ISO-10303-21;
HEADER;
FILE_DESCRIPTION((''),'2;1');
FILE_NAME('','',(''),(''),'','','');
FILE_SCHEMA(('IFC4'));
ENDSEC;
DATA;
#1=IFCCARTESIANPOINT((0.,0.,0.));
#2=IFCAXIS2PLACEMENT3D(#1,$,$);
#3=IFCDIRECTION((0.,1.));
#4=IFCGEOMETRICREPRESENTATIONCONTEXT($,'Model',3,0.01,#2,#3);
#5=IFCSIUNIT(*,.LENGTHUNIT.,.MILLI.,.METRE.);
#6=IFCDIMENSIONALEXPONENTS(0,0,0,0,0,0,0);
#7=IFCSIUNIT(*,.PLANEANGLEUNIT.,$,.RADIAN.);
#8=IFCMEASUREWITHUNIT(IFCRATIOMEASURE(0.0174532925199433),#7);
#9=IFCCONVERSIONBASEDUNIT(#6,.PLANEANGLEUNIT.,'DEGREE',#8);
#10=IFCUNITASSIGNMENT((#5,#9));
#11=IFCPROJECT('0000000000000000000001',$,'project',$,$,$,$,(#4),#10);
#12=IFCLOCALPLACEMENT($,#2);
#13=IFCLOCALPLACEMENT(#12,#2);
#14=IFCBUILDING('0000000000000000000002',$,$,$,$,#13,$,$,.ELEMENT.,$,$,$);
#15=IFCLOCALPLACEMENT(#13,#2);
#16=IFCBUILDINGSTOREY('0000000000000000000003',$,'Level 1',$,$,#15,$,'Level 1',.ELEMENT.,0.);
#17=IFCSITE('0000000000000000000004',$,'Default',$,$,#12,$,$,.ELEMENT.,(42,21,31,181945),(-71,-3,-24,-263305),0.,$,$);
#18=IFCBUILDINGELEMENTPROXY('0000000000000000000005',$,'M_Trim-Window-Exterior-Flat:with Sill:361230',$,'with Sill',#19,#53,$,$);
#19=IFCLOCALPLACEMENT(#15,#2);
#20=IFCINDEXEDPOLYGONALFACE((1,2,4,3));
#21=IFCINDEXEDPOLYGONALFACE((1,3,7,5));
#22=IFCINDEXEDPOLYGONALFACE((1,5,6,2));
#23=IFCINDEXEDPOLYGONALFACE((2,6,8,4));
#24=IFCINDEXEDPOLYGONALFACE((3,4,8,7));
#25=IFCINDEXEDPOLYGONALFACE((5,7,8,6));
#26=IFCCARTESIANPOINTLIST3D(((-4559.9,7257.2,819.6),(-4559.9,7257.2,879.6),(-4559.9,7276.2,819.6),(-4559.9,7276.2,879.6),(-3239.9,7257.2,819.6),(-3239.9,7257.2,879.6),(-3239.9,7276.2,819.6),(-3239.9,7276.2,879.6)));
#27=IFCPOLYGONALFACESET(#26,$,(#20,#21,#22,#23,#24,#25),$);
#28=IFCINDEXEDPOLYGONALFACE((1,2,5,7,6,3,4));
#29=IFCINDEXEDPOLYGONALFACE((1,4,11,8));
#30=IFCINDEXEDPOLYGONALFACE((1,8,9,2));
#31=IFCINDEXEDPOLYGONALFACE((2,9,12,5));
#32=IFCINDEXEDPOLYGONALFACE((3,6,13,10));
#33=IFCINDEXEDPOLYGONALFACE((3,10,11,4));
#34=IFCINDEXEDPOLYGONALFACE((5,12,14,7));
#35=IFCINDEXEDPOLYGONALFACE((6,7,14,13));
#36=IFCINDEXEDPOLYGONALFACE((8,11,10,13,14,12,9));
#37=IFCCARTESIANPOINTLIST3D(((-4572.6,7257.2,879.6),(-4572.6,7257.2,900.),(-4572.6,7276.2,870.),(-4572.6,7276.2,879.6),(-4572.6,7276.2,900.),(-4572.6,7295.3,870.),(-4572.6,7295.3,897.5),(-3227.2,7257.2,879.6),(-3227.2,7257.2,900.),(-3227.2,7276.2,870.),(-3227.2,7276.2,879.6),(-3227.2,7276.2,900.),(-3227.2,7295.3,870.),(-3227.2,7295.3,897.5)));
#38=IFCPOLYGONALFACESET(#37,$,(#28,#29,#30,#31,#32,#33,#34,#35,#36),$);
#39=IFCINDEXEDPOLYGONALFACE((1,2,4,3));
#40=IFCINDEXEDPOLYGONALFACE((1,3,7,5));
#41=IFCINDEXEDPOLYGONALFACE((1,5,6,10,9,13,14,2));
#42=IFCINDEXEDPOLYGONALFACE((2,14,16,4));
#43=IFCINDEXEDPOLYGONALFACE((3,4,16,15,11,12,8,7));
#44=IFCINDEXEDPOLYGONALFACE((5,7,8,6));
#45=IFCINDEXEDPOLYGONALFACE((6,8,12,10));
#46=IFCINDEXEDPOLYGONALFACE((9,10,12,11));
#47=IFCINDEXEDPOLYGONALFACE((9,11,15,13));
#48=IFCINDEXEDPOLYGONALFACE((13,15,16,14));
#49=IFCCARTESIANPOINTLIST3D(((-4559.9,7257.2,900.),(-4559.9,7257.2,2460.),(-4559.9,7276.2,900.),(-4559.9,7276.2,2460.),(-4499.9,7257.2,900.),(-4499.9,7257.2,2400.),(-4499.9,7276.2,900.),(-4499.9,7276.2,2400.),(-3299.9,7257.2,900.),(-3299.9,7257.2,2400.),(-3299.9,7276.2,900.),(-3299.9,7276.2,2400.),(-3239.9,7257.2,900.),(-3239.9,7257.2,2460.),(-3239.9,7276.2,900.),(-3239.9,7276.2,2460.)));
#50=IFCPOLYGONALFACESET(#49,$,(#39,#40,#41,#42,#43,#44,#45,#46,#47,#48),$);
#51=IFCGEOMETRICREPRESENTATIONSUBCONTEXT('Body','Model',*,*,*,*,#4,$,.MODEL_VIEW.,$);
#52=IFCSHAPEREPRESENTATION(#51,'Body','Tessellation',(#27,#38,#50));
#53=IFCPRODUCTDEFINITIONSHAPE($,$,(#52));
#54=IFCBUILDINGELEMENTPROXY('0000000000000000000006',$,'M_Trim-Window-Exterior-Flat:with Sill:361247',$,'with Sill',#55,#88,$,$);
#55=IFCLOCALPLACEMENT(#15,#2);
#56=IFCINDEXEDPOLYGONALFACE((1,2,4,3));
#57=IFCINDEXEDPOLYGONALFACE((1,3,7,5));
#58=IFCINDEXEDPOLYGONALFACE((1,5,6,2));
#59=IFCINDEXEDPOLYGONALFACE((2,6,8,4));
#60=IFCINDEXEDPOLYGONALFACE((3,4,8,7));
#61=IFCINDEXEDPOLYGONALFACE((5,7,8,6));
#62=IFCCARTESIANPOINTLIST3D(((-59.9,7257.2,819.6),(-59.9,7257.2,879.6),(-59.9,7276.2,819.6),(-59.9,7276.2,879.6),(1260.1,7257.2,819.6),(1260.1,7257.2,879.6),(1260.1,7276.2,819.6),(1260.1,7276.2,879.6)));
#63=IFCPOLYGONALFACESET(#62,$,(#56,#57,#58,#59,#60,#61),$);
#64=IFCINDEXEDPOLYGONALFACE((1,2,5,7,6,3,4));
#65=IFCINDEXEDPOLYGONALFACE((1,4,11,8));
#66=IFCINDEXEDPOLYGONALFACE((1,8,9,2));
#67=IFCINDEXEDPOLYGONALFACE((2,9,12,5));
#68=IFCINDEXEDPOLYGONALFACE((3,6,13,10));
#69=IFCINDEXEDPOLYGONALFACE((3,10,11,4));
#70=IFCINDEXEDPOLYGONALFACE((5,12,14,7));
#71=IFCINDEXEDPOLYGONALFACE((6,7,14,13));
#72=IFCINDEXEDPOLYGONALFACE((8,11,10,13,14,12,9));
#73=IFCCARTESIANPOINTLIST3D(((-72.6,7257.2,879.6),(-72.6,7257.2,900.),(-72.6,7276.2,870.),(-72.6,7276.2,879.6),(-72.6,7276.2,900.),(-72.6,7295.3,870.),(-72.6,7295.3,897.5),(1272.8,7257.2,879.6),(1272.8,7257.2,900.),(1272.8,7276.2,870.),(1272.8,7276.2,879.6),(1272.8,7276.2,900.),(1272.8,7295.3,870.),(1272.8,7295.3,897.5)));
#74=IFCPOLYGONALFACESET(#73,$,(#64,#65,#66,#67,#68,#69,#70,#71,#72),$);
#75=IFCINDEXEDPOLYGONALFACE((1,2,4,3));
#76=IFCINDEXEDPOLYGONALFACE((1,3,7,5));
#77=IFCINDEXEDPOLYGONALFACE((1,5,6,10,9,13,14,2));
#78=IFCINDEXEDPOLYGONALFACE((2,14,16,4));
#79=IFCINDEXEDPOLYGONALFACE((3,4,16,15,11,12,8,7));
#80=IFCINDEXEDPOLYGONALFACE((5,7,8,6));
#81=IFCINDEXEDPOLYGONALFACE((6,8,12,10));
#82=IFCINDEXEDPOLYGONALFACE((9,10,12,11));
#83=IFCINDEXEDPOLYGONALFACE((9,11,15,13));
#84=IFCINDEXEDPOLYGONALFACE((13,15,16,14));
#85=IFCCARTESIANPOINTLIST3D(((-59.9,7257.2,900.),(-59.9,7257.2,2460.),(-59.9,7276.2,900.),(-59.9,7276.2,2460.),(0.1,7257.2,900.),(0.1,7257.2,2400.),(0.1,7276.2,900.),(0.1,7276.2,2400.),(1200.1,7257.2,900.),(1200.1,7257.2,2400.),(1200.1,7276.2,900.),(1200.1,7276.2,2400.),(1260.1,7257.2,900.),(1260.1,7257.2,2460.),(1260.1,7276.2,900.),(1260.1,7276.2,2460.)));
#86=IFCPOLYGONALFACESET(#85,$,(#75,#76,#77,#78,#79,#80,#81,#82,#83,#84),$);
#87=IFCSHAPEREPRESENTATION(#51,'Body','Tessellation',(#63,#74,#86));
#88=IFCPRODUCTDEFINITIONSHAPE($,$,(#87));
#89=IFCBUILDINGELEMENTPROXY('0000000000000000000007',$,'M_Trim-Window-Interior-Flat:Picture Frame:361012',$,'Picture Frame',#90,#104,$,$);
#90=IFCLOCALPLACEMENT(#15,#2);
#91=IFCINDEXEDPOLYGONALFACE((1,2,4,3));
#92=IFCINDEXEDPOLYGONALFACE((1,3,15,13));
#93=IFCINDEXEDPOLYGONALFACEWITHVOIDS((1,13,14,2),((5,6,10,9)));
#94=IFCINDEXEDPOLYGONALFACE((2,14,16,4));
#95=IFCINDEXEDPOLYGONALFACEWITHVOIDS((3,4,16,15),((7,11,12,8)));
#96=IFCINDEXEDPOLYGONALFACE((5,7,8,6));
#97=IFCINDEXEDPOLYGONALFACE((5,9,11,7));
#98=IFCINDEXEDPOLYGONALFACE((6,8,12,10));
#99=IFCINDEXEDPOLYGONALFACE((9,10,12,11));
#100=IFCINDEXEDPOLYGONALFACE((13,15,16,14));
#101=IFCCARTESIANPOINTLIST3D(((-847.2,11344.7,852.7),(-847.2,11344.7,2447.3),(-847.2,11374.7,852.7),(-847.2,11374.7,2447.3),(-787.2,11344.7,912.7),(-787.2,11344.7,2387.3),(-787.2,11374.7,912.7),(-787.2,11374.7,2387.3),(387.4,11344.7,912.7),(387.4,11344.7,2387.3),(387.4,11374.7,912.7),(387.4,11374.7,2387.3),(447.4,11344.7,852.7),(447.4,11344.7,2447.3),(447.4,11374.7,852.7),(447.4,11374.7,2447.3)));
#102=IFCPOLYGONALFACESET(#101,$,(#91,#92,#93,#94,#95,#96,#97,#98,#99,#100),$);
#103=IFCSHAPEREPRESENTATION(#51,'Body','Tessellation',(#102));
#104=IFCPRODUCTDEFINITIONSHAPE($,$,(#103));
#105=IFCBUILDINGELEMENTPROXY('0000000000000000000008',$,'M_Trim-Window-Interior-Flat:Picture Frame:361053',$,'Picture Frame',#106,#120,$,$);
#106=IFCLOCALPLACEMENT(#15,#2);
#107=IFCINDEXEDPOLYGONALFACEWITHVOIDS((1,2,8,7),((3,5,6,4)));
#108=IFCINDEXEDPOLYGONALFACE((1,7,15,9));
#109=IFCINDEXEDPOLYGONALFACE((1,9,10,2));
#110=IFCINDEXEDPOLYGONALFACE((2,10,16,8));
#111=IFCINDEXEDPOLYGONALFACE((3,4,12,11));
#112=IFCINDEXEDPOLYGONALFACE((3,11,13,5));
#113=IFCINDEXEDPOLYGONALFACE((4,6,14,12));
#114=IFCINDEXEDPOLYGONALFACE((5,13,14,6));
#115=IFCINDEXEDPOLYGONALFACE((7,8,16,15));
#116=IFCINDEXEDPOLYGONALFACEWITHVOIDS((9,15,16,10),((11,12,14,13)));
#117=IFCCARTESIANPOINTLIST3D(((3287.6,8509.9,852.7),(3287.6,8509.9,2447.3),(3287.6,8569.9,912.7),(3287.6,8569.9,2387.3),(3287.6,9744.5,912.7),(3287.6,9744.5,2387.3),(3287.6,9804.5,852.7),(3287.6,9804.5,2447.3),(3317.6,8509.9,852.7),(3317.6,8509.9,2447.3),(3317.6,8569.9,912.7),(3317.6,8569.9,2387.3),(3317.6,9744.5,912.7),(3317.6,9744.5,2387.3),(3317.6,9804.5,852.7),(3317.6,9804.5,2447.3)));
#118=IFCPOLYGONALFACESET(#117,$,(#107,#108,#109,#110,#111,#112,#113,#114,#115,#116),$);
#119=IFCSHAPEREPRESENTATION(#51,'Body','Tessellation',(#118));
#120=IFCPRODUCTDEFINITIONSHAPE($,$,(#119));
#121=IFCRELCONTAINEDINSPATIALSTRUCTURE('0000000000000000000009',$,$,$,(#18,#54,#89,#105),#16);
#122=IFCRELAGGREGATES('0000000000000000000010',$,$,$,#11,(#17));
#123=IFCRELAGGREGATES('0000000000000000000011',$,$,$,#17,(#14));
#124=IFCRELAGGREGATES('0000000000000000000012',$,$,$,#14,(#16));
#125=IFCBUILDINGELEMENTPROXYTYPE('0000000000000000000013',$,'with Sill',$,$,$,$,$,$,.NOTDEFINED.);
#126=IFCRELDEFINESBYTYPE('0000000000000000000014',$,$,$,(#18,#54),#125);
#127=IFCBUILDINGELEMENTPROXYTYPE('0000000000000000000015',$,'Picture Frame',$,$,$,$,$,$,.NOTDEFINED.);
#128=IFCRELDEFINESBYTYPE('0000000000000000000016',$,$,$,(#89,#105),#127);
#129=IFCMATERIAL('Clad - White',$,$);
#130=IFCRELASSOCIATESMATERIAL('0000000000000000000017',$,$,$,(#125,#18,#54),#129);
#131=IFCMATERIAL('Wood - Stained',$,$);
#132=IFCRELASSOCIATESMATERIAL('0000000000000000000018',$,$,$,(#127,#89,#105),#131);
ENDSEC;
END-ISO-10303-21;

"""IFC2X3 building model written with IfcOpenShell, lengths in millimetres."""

from ifc_helpers import new_model, entity, si_unit, converted_unit, direction, frame, frame_2d, origin, place, context, subcontext, project, spatial, polyline, rectangle, outline, extrude, source, transform, mapped, material, type_object, type_shapes, element, save


model = new_model("IFC2X3")

# Units and contexts
model_context = context("Model", 3, precision=0.01, world=origin(), true_north=direction((0.0, 1.0)))
body_context = subcontext(model_context, "Body", "Model", "MODEL_VIEW")
ifc_project = project(units=[si_unit("LENGTHUNIT", "METRE", prefix="MILLI"), converted_unit("PLANEANGLEUNIT", "DEGREE", entity("IfcRatioMeasure", 0.0174532925199433), si_unit("PLANEANGLEUNIT", "RADIAN"), dimensions=[0, 0, 0, 0, 0, 0, 0])], contexts=[model_context])

# Site, building, storey
site_placement = place(None, origin())
site = spatial("IfcSite", under=ifc_project, at=site_placement, Name="Default", CompositionType="ELEMENT", RefLatitude=(42, 21, 31, 181945), RefLongitude=(-71, -3, -24, -263305), RefElevation=0.0)
building_placement = place(site_placement, origin())
building = spatial("IfcBuilding", under=site, at=building_placement, CompositionType="ELEMENT")
storey_placement = place(building_placement, origin())
storey = spatial("IfcBuildingStorey", under=building, at=storey_placement, Name="Level 1", LongName="Level 1", CompositionType="ELEMENT", Elevation=0.0)

# Building element proxies
ifc_material_1 = material(Name="Clad - White")
ifc_material_2 = material(Name="Wood - Stained")
building_element_proxy_type_1 = type_object("IfcBuildingElementProxyType", Name="with Sill", PredefinedType="NOTDEFINED", material=ifc_material_1)
shared_shape_1 = source(origin(), body_context, "Body", "SweptSolid", [
    extrude(rectangle(XDim=1320.0, YDim=60.0, at=frame_2d((0.0, 0.0), x_axis=(1.0, 0.0))), frame((0.0, -1550.4, 0.0), z_axis=(0.0, 0.0, 1.0), x_axis=(-1.0, 0.0, 0.0)), (0.0, 0.0, 1.0), 19.1),
    extrude(outline(polyline([(-19.0, -15.2), (0.0, -15.2), (0.0, -5.7), (19.0, -5.7), (19.0, 14.8), (0.0, 14.8), (-19.0, 12.3), (-19.0, -15.2)])), frame((-672.7, -1514.8, 19.0), z_axis=(1.0, 0.0, 0.0), x_axis=(0.0, 0.0, -1.0)), (0.0, 0.0, 1.0), 1345.4),
    extrude(outline(polyline([(-795.0, -660.0), (765.0, -660.0), (765.0, -600.0), (-735.0, -600.0), (-735.0, 600.0), (765.0, 600.0), (765.0, 660.0), (-795.0, 660.0), (-795.0, -660.0)])), frame((0.0, -735.0, 0.0), z_axis=(0.0, 0.0, 1.0), x_axis=(0.0, -1.0, 0.0)), (0.0, 0.0, 1.0), 19.1),
])
type_shapes(building_element_proxy_type_1, [shared_shape_1])
for number, where, z_axis, x_axis, name in (
    (1, (-3899.9, 7257.2, 2400.0), (0.0, 1.0, 0.0), (-1.0, 0.0, 0.0), "M_Trim-Window-Exterior-Flat:with Sill:361230"),
    (2, (600.1, 7257.2, 2400.0), (0.0, 1.0, 0.0), (-1.0, 0.0, 0.0), "M_Trim-Window-Exterior-Flat:with Sill:361247"),
):
    element("IfcBuildingElementProxy", number, at=place(storey_placement, frame(where, z_axis=z_axis, x_axis=x_axis)), inside=storey, type_object=building_element_proxy_type_1, material=ifc_material_1, Name=name, ObjectType="with Sill", context=body_context, shape_type="MappedRepresentation", body=[
        mapped(shared_shape_1, transform((0.0, 0.0, 0.0), scale=1.0)),
    ])
building_element_proxy_type_2 = type_object("IfcBuildingElementProxyType", Name="Picture Frame", PredefinedType="NOTDEFINED", material=ifc_material_2)
shared_shape_2 = source(origin(), body_context, "Body", "SweptSolid", [
    extrude(outline(polyline([(-647.3, -797.3), (647.3, -797.3), (647.3, 797.3), (-647.3, 797.3), (-647.3, -797.3)]), holes=[polyline([(-587.3, -737.3), (-587.3, 737.3), (587.3, 737.3), (587.3, -737.3), (-587.3, -737.3)])]), frame((0.0, -750.0, 0.0), z_axis=(0.0, 0.0, 1.0), x_axis=(-1.0, 0.0, 0.0)), (0.0, 0.0, 1.0), 30.0),
])
type_shapes(building_element_proxy_type_2, [shared_shape_2])
for number, where, z_axis, x_axis, name in (
    (3, (-199.9, 11344.7, 2400.0), (0.0, 1.0, 0.0), (-1.0, 0.0, 0.0), "M_Trim-Window-Interior-Flat:Picture Frame:361012"),
    (4, (3287.6, 9157.2, 2400.0), (1.0, 0.0, 0.0), (0.0, 1.0, 0.0), "M_Trim-Window-Interior-Flat:Picture Frame:361053"),
):
    element("IfcBuildingElementProxy", number, at=place(storey_placement, frame(where, z_axis=z_axis, x_axis=x_axis)), inside=storey, type_object=building_element_proxy_type_2, material=ifc_material_2, Name=name, ObjectType="Picture Frame", context=body_context, shape_type="MappedRepresentation", body=[
        mapped(shared_shape_2, transform((0.0, 0.0, 0.0), scale=1.0)),
    ])

save(model, "model.ifc")
